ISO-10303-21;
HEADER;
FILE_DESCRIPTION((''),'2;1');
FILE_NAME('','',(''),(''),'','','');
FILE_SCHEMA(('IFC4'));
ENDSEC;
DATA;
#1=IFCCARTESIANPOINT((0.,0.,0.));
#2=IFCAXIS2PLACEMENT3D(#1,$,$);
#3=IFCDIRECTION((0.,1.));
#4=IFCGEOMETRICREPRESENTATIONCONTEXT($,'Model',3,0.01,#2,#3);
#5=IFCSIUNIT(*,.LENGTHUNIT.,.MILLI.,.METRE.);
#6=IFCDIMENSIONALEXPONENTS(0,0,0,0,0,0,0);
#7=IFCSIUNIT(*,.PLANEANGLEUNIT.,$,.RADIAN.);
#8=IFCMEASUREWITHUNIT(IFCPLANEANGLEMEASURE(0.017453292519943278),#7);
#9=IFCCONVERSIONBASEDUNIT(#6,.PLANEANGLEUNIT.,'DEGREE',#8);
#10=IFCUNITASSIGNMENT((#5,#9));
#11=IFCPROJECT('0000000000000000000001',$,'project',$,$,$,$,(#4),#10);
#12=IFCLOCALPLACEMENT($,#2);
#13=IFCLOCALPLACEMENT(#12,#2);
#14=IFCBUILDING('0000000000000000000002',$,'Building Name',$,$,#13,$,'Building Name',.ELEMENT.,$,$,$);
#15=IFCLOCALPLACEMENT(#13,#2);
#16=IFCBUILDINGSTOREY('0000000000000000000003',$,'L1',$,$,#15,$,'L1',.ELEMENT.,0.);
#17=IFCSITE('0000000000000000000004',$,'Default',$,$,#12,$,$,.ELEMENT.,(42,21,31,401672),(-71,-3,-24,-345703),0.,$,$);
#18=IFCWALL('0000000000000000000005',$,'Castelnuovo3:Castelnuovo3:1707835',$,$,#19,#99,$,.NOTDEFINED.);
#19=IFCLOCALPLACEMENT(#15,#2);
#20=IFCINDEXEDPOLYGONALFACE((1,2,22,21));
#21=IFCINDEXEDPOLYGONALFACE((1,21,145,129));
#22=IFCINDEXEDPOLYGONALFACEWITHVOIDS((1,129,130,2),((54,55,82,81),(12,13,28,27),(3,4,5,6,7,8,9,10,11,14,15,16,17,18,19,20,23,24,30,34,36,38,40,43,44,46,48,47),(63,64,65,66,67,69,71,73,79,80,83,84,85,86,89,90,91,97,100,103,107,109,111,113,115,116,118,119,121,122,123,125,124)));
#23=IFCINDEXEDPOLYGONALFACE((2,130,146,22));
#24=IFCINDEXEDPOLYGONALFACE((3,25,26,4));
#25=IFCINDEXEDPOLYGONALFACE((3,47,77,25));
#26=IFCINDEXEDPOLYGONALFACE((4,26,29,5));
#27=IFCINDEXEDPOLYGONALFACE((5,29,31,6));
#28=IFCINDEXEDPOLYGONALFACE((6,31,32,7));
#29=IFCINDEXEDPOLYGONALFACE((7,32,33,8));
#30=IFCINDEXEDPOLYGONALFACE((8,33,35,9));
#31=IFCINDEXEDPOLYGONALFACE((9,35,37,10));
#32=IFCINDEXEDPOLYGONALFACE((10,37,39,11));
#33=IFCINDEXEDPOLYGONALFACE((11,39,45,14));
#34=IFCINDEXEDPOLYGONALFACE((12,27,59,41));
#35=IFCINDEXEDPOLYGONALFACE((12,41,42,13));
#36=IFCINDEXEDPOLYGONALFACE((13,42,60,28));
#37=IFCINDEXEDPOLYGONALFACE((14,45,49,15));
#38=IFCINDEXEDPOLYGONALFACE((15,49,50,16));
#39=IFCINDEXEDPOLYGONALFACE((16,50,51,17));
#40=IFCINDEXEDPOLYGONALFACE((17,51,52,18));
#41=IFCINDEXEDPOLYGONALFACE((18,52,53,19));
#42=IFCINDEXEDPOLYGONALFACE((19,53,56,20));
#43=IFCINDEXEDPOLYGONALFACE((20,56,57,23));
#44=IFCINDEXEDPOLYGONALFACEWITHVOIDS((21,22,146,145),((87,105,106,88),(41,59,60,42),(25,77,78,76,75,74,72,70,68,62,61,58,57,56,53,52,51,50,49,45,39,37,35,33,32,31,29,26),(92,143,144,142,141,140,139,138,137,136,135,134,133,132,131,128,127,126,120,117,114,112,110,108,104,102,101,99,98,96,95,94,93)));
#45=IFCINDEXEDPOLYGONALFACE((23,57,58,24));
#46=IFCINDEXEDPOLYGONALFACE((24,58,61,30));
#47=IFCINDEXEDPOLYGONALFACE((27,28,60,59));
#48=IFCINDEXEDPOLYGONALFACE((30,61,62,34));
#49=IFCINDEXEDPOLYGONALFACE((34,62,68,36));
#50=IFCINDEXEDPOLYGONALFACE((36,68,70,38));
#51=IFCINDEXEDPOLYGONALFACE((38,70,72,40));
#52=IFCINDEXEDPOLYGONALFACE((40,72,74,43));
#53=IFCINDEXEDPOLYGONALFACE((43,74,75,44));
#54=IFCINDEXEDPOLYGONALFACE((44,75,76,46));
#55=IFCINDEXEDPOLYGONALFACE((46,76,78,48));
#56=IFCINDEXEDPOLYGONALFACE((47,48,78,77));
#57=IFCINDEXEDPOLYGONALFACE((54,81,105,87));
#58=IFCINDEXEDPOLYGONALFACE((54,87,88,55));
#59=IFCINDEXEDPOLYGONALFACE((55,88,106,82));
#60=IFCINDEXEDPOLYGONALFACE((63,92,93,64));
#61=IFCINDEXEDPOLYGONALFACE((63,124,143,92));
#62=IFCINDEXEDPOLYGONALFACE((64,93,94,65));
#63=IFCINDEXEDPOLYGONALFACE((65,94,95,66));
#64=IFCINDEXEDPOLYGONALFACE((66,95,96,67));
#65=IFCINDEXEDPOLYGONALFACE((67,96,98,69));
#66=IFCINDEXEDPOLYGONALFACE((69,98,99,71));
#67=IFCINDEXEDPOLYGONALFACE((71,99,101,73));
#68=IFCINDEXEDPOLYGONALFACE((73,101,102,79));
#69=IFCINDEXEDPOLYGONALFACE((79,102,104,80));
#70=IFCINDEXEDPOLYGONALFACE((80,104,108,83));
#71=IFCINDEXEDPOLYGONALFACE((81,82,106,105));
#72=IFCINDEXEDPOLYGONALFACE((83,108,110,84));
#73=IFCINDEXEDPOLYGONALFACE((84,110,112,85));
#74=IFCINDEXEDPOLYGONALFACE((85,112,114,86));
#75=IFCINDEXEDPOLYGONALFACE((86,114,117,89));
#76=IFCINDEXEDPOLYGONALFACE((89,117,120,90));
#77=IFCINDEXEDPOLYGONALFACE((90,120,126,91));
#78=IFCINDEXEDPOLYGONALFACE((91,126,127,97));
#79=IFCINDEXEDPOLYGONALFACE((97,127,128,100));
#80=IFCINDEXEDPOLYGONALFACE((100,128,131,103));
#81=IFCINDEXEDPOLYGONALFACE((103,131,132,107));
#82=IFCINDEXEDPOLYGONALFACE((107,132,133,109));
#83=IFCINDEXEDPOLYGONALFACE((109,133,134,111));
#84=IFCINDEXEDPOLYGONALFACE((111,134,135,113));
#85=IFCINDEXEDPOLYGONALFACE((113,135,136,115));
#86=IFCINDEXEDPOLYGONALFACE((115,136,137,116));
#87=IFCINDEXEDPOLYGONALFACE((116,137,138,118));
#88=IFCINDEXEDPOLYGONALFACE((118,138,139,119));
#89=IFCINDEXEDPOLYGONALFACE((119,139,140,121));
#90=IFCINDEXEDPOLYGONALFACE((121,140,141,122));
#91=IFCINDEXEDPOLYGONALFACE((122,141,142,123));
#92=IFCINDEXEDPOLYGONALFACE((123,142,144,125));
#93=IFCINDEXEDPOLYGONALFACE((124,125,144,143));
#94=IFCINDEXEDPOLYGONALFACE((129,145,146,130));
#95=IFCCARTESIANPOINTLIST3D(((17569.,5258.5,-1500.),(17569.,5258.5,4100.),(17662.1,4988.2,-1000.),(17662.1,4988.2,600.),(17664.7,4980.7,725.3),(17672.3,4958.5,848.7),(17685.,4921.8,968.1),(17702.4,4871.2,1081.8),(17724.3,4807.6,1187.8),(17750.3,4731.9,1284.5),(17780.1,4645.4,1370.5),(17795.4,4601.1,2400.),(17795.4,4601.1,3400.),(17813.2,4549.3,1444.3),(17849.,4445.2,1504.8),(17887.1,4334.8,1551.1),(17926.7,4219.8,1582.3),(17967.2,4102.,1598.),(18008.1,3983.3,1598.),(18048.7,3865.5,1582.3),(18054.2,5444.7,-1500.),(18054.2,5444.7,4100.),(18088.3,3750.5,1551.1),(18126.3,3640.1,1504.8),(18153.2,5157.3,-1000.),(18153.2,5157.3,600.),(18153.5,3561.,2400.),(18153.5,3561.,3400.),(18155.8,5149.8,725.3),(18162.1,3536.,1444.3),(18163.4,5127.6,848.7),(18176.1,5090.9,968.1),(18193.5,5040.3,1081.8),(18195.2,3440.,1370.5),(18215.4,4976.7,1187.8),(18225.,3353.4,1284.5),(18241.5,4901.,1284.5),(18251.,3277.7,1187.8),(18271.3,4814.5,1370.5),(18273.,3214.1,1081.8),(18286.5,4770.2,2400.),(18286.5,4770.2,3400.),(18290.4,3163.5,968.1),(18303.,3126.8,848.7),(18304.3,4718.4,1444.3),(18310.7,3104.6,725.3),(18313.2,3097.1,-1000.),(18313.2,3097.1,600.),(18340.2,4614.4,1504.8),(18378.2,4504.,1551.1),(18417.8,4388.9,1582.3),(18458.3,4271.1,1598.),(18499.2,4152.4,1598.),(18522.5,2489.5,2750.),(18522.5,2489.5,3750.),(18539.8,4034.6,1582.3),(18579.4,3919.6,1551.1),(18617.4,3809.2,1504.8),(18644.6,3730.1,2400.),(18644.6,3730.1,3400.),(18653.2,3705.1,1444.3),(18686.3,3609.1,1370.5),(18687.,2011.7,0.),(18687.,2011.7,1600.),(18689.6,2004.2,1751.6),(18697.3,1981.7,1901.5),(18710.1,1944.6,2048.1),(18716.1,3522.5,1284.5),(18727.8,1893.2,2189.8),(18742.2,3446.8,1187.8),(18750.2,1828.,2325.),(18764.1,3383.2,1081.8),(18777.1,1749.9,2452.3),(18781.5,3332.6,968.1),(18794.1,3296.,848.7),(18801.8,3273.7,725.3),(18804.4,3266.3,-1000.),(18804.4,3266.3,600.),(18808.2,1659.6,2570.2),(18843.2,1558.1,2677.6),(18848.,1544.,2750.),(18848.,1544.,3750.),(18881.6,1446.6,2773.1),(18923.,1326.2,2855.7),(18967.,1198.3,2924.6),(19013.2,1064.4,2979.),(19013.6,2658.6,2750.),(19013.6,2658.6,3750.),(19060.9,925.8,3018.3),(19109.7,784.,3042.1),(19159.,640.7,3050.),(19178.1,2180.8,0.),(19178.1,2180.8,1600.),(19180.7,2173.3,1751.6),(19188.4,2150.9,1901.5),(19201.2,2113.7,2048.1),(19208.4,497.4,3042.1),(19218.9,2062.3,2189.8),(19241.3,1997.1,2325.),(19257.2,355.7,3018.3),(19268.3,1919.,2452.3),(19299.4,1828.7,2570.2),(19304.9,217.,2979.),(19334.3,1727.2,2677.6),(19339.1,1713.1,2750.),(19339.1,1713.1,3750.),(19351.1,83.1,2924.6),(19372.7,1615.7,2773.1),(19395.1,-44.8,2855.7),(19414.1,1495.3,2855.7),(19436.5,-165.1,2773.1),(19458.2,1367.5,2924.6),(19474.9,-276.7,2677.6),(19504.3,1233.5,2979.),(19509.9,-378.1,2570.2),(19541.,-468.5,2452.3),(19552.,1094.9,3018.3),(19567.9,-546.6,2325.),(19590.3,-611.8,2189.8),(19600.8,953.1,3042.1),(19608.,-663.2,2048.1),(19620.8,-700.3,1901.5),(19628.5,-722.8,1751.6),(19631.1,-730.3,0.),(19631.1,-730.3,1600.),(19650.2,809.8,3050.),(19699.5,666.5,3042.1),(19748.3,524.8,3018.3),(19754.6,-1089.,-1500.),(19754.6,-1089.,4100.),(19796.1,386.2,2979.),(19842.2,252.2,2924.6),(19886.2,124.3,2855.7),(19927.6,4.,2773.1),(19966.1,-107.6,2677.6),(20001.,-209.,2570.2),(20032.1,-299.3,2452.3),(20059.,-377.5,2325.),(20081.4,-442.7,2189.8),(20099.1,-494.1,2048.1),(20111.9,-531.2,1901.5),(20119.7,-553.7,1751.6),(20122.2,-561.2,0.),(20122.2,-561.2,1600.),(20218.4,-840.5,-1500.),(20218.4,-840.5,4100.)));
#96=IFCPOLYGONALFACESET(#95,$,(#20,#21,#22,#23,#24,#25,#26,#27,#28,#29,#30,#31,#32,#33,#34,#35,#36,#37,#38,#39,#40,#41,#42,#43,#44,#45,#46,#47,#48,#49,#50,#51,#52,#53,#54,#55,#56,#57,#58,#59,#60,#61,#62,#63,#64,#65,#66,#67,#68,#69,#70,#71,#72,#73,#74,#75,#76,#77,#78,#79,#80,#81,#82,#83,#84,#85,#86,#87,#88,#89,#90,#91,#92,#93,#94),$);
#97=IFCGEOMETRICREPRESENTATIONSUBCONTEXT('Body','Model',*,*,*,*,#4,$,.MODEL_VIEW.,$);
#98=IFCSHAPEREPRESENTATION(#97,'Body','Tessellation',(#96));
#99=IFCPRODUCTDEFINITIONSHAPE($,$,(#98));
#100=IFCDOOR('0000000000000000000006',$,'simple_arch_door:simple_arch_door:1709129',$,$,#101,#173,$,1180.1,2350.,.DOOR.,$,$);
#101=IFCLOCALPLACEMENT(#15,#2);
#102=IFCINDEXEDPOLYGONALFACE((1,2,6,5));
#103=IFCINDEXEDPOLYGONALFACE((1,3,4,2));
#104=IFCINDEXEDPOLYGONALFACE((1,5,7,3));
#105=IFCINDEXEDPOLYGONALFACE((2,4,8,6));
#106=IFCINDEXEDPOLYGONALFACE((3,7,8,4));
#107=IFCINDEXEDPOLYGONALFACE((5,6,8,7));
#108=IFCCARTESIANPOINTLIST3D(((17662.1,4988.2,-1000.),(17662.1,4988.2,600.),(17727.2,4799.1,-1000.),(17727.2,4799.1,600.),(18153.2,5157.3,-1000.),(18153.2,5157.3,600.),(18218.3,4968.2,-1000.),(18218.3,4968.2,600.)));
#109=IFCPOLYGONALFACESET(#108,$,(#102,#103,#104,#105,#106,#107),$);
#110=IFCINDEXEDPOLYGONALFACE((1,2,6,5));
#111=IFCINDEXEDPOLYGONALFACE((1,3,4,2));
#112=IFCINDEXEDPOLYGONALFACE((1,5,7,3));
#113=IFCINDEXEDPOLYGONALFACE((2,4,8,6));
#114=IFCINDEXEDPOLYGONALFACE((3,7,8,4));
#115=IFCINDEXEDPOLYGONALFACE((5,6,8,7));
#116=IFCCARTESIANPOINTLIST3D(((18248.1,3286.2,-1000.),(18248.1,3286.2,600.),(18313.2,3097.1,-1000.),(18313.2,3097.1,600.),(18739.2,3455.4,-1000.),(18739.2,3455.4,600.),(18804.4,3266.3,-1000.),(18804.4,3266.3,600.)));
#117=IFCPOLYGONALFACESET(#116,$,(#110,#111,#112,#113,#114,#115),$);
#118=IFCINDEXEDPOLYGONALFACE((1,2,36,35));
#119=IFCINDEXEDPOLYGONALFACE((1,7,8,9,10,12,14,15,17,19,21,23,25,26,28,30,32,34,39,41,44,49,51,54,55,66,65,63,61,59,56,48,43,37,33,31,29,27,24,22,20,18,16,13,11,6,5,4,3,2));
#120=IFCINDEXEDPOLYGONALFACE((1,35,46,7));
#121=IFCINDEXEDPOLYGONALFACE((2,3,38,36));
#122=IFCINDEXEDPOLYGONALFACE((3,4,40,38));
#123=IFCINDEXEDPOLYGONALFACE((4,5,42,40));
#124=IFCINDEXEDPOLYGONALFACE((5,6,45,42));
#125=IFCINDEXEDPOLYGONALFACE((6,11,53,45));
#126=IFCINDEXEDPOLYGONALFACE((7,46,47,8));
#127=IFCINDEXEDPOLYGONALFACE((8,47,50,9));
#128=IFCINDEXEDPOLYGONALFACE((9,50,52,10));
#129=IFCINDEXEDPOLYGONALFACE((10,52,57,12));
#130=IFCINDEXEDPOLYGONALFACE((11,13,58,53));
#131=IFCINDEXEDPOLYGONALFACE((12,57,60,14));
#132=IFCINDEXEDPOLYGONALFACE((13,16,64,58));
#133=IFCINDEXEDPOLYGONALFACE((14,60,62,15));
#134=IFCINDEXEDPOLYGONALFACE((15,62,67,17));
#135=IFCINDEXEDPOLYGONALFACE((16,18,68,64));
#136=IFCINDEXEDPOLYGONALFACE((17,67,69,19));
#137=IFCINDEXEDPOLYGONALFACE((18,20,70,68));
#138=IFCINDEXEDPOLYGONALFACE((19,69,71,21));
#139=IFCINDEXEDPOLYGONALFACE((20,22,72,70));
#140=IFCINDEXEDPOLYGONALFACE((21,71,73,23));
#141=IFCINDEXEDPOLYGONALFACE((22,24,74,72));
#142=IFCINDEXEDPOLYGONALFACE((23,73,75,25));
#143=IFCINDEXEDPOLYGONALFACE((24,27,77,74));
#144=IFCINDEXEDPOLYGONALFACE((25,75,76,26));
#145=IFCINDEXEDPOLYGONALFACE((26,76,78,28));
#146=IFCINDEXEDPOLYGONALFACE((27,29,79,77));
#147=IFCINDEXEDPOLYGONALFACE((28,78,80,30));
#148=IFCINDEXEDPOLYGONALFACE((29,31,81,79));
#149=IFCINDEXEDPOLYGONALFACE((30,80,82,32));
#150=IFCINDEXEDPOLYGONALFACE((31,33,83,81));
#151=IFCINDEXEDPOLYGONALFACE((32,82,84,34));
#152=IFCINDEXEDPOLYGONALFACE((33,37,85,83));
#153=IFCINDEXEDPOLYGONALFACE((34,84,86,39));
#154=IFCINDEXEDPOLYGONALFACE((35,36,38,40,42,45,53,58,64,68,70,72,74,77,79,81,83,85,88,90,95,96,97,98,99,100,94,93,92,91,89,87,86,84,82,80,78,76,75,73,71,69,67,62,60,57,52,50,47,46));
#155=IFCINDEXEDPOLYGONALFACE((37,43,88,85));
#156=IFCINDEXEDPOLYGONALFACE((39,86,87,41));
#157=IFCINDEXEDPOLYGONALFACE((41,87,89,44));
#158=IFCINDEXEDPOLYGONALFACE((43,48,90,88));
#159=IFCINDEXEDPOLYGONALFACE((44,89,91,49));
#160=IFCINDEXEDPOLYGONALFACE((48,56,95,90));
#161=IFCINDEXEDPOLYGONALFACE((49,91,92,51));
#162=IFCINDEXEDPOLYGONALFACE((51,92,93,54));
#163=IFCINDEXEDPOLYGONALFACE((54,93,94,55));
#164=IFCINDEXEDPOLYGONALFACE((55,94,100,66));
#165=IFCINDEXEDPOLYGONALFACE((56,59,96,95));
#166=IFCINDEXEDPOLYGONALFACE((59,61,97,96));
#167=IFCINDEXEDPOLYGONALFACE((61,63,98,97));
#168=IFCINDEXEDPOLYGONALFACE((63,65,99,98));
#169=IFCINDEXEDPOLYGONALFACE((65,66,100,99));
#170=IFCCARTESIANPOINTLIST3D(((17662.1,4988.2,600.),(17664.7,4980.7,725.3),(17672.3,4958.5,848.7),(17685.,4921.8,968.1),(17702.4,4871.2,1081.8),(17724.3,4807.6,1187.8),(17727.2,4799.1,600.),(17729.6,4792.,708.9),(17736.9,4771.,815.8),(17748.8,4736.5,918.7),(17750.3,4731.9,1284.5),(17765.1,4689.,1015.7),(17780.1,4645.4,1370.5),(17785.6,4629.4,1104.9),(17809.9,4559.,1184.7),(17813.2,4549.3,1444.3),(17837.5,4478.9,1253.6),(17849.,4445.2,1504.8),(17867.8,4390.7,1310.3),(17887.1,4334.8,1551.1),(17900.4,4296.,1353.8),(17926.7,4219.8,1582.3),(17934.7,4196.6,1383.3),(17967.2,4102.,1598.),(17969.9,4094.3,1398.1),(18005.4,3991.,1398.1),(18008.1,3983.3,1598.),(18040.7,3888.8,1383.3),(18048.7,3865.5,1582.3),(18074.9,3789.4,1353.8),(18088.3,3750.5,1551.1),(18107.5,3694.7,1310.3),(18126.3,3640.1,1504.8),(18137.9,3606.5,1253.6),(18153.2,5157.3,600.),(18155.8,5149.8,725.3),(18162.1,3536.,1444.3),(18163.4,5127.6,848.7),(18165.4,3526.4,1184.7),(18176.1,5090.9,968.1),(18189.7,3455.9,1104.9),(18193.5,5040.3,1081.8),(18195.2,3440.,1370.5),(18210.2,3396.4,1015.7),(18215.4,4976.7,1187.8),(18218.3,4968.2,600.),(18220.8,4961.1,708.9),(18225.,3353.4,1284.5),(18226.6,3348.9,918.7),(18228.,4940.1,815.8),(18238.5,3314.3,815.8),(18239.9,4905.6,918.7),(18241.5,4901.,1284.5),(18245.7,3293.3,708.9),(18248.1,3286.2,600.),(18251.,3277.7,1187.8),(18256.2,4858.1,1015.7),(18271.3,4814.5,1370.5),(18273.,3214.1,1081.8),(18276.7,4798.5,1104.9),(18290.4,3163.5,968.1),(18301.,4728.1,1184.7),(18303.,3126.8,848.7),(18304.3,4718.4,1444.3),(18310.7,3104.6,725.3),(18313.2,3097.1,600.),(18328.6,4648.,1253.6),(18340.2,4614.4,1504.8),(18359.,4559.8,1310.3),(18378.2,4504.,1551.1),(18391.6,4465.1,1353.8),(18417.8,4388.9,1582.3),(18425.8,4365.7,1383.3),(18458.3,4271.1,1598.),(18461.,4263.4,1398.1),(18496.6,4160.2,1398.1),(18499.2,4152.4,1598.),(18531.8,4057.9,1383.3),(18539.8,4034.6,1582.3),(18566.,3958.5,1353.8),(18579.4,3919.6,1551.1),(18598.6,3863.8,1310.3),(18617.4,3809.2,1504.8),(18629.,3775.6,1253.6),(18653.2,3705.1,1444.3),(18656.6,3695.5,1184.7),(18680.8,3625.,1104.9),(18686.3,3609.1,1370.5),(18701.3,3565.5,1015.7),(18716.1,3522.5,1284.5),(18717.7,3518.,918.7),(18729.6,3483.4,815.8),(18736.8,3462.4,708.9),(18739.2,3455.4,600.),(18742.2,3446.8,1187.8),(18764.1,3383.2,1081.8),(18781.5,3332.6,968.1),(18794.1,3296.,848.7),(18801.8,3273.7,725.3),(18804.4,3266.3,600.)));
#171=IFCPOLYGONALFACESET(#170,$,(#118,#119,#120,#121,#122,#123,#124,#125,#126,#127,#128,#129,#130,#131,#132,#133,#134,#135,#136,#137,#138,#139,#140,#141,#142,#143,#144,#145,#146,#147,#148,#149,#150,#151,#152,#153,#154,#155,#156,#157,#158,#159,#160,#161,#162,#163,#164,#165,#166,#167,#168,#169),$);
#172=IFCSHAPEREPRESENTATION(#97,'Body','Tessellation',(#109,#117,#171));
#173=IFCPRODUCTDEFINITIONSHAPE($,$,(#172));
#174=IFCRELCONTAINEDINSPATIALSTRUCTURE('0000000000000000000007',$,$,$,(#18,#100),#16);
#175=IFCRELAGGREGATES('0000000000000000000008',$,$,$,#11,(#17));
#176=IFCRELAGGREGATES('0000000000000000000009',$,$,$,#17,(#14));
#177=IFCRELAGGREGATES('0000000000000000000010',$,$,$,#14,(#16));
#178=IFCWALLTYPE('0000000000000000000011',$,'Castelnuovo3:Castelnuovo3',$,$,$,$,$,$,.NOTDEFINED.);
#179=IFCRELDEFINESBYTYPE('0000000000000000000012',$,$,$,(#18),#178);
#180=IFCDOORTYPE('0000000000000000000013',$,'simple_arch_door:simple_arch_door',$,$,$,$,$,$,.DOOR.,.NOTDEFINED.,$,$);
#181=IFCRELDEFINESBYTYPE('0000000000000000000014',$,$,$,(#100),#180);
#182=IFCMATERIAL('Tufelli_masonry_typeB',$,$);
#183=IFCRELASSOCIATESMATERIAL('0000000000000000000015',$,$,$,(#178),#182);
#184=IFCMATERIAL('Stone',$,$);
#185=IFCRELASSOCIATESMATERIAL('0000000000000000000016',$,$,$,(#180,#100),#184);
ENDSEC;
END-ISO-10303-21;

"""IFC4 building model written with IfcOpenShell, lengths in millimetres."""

from ifc_helpers import new_model, entity, si_unit, converted_unit, direction, frame, origin, place, context, subcontext, project, spatial, line, arc, indexed_curve, outline, extrude, source, transform, mapped, material, type_object, type_shapes, element, save


model = new_model("IFC4")

# Units and contexts
model_context = context("Model", 3, precision=0.01, world=origin(), true_north=direction((0.0, 1.0)))
body_context = subcontext(model_context, "Body", "Model", "MODEL_VIEW")
ifc_project = project(units=[si_unit("LENGTHUNIT", "METRE", prefix="MILLI"), converted_unit("PLANEANGLEUNIT", "DEGREE", entity("IfcPlaneAngleMeasure", 0.017453292519943278), si_unit("PLANEANGLEUNIT", "RADIAN"), dimensions=[0, 0, 0, 0, 0, 0, 0])], contexts=[model_context])

# Site, building, storey
site_placement = place(None, origin())
site = spatial("IfcSite", under=ifc_project, at=site_placement, Name="Default", CompositionType="ELEMENT", RefLatitude=(42, 21, 31, 401672), RefLongitude=(-71, -3, -24, -345703), RefElevation=0.0)
building_placement = place(site_placement, origin())
building = spatial("IfcBuilding", under=site, at=building_placement, Name="Building Name", LongName="Building Name", CompositionType="ELEMENT")
storey_placement = place(building_placement, origin())
storey = spatial("IfcBuildingStorey", under=building, at=storey_placement, Name="L1", LongName="L1", CompositionType="ELEMENT", Elevation=0.0)

# Shared definitions
ifc_material_1 = material(Name="Tufelli_masonry_typeB")

# Shared definitions
ifc_material_2 = material(Name="Stone")

# Wall, openings
wall_type_1 = type_object("IfcWallType", Name="Castelnuovo3:Castelnuovo3", PredefinedType="NOTDEFINED", material=ifc_material_1)
wall_1_placement = place(storey_placement, frame((17569.0, -1089.0, -1500.0), z_axis=(0.0, 0.0, 1.0), x_axis=(0.0, 1.0, 0.0)))
wall_1 = element("IfcWall", 1, at=wall_1_placement, inside=storey, type_object=wall_type_1, Name="Castelnuovo3:Castelnuovo3:1707835", PredefinedType="NOTDEFINED", context=body_context, shape_type="SweptSolid", body=[
    extrude(outline(indexed_curve([(-376.4, -3338.1), (143.3, -3338.1), (377.6, 3371.0), (-144.5, 3305.2), (-376.4, -3338.1)], self_intersect=False)), frame((3282.4, -1330.1, 0.0), z_axis=(0.0, 0.0, 1.0), x_axis=(-0.358368, 0.93358, 0.0)), (0.0, 0.0, 1.0), 5600.0),
])
opening_1_placement = place(wall_1_placement, origin())
element("IfcOpeningElement", 2, at=opening_1_placement, cuts=wall_1, PredefinedType="OPENING", context=body_context, shape_type="SweptSolid", body=[
    extrude(outline(indexed_curve([(-500.0, -500.0), (500.0, -500.0), (500.0, 500.0), (-500.0, 500.0), (-500.0, -500.0)], self_intersect=False)), frame((3099.0, -1096.6, 4750.0), z_axis=(0.325568, -0.945519, 0.0), x_axis=(0.0, 0.0, 1.0)), (0.0, 0.0, 1.0), 612.9),
])
opening_2_placement = place(wall_1_placement, origin())
element("IfcOpeningElement", 3, at=opening_2_placement, cuts=wall_1, PredefinedType="OPENING", context=body_context, shape_type="SweptSolid", body=[
    extrude(outline(indexed_curve([(-500.0, -550.0), (500.0, -550.0), (500.0, 550.0), (-500.0, 550.0), (-500.0, -550.0)], self_intersect=False)), frame((5163.3, -385.8, 4400.0), z_axis=(0.325568, -0.945519, 0.0), x_axis=(0.0, 0.0, 1.0)), (0.0, 0.0, 1.0), 612.9),
])
opening_3_placement = place(wall_1_placement, origin())
element("IfcOpeningElement", 4, at=opening_3_placement, cuts=wall_1, PredefinedType="OPENING", context=body_context, shape_type="SweptSolid", body=[
    extrude(outline(indexed_curve([(-800.0, -1000.0), (800.0, -1000.0), (800.0, 1000.0), (-800.0, 1000.0), (-1800.0, 0.0)], segments=[line(1, 2, 3, 4), arc(4, 5, 1)], self_intersect=False)), frame((5124.9, -399.0, 1300.0), z_axis=(0.325568, -0.945519, 0.0), x_axis=(0.0, 0.0, -1.0)), (0.0, 0.0, 1.0), 612.9),
])
opening_4_placement = place(wall_1_placement, origin())
element("IfcOpeningElement", 5, at=opening_4_placement, cuts=wall_1, PredefinedType="OPENING", context=body_context, shape_type="SweptSolid", body=[
    extrude(outline(indexed_curve([(-800.0, -1450.0), (800.0, -1450.0), (800.0, 1450.0), (-800.0, 1450.0), (-2250.0, 0.0)], segments=[line(1, 2, 3, 4), arc(4, 5, 1)], self_intersect=False)), frame((1905.6, -2100.8, 2300.0), z_axis=(-0.325568, 0.945519, 0.0), x_axis=(0.0, 0.0, -1.0)), (0.0, 0.0, 1.0), 612.9),
])

# Door
door_type_1 = type_object("IfcDoorType", Name="simple_arch_door:simple_arch_door", OperationType="NOTDEFINED", PredefinedType="DOOR", material=ifc_material_2)
shared_shape_1 = source(origin(), body_context, "Body", "SweptSolid", [
    extrude(outline(indexed_curve([(-100.0, -259.7), (100.0, -259.7), (100.0, 259.7), (-100.0, 259.7), (-100.0, -259.7)], self_intersect=False)), frame((900.0, 0.0, 0.0), z_axis=(0.0, 0.0, 1.0), x_axis=(-1.0, 0.0, 0.0)), (0.0, 0.0, 1.0), 1600.0),
    extrude(outline(indexed_curve([(-100.0, -259.7), (100.0, -259.7), (100.0, 259.7), (-100.0, 259.7), (-100.0, -259.7)], self_intersect=False)), frame((-900.0, 0.0, 0.0), z_axis=(0.0, 0.0, 1.0), x_axis=(-1.0, 0.0, 0.0)), (0.0, 0.0, 1.0), 1600.0),
    extrude(outline(indexed_curve([(-1000.0, 0.0), (0.0, -1000.0), (1000.0, 0.0), (800.0, 0.0), (0.0, -800.0), (-800.0, 0.0)], segments=[arc(1, 2, 3), line(3, 4), arc(4, 5, 6), line(6, 1)], self_intersect=False)), frame((0.0, -259.7, 1600.0), z_axis=(0.0, 1.0, 0.0), x_axis=(1.0, 0.0, 0.0)), (0.0, 0.0, 1.0), 519.4),
])
type_shapes(door_type_1, [shared_shape_1])
door_1_placement = place(storey_placement, frame((18233.2, 4127.2, -1000.0), z_axis=(0.0, 0.0, 1.0), x_axis=(-0.325568, 0.945519, 0.0)))
element("IfcDoor", 6, at=door_1_placement, inside=storey, type_object=door_type_1, material=ifc_material_2, Name="simple_arch_door:simple_arch_door:1709129", OverallHeight=1180.1, OverallWidth=2350.0, PredefinedType="DOOR", context=body_context, shape_type="MappedRepresentation", body=[
    mapped(shared_shape_1, transform((0.0, 0.0, 0.0), scale=1.0)),
])

save(model, "model.ifc")
